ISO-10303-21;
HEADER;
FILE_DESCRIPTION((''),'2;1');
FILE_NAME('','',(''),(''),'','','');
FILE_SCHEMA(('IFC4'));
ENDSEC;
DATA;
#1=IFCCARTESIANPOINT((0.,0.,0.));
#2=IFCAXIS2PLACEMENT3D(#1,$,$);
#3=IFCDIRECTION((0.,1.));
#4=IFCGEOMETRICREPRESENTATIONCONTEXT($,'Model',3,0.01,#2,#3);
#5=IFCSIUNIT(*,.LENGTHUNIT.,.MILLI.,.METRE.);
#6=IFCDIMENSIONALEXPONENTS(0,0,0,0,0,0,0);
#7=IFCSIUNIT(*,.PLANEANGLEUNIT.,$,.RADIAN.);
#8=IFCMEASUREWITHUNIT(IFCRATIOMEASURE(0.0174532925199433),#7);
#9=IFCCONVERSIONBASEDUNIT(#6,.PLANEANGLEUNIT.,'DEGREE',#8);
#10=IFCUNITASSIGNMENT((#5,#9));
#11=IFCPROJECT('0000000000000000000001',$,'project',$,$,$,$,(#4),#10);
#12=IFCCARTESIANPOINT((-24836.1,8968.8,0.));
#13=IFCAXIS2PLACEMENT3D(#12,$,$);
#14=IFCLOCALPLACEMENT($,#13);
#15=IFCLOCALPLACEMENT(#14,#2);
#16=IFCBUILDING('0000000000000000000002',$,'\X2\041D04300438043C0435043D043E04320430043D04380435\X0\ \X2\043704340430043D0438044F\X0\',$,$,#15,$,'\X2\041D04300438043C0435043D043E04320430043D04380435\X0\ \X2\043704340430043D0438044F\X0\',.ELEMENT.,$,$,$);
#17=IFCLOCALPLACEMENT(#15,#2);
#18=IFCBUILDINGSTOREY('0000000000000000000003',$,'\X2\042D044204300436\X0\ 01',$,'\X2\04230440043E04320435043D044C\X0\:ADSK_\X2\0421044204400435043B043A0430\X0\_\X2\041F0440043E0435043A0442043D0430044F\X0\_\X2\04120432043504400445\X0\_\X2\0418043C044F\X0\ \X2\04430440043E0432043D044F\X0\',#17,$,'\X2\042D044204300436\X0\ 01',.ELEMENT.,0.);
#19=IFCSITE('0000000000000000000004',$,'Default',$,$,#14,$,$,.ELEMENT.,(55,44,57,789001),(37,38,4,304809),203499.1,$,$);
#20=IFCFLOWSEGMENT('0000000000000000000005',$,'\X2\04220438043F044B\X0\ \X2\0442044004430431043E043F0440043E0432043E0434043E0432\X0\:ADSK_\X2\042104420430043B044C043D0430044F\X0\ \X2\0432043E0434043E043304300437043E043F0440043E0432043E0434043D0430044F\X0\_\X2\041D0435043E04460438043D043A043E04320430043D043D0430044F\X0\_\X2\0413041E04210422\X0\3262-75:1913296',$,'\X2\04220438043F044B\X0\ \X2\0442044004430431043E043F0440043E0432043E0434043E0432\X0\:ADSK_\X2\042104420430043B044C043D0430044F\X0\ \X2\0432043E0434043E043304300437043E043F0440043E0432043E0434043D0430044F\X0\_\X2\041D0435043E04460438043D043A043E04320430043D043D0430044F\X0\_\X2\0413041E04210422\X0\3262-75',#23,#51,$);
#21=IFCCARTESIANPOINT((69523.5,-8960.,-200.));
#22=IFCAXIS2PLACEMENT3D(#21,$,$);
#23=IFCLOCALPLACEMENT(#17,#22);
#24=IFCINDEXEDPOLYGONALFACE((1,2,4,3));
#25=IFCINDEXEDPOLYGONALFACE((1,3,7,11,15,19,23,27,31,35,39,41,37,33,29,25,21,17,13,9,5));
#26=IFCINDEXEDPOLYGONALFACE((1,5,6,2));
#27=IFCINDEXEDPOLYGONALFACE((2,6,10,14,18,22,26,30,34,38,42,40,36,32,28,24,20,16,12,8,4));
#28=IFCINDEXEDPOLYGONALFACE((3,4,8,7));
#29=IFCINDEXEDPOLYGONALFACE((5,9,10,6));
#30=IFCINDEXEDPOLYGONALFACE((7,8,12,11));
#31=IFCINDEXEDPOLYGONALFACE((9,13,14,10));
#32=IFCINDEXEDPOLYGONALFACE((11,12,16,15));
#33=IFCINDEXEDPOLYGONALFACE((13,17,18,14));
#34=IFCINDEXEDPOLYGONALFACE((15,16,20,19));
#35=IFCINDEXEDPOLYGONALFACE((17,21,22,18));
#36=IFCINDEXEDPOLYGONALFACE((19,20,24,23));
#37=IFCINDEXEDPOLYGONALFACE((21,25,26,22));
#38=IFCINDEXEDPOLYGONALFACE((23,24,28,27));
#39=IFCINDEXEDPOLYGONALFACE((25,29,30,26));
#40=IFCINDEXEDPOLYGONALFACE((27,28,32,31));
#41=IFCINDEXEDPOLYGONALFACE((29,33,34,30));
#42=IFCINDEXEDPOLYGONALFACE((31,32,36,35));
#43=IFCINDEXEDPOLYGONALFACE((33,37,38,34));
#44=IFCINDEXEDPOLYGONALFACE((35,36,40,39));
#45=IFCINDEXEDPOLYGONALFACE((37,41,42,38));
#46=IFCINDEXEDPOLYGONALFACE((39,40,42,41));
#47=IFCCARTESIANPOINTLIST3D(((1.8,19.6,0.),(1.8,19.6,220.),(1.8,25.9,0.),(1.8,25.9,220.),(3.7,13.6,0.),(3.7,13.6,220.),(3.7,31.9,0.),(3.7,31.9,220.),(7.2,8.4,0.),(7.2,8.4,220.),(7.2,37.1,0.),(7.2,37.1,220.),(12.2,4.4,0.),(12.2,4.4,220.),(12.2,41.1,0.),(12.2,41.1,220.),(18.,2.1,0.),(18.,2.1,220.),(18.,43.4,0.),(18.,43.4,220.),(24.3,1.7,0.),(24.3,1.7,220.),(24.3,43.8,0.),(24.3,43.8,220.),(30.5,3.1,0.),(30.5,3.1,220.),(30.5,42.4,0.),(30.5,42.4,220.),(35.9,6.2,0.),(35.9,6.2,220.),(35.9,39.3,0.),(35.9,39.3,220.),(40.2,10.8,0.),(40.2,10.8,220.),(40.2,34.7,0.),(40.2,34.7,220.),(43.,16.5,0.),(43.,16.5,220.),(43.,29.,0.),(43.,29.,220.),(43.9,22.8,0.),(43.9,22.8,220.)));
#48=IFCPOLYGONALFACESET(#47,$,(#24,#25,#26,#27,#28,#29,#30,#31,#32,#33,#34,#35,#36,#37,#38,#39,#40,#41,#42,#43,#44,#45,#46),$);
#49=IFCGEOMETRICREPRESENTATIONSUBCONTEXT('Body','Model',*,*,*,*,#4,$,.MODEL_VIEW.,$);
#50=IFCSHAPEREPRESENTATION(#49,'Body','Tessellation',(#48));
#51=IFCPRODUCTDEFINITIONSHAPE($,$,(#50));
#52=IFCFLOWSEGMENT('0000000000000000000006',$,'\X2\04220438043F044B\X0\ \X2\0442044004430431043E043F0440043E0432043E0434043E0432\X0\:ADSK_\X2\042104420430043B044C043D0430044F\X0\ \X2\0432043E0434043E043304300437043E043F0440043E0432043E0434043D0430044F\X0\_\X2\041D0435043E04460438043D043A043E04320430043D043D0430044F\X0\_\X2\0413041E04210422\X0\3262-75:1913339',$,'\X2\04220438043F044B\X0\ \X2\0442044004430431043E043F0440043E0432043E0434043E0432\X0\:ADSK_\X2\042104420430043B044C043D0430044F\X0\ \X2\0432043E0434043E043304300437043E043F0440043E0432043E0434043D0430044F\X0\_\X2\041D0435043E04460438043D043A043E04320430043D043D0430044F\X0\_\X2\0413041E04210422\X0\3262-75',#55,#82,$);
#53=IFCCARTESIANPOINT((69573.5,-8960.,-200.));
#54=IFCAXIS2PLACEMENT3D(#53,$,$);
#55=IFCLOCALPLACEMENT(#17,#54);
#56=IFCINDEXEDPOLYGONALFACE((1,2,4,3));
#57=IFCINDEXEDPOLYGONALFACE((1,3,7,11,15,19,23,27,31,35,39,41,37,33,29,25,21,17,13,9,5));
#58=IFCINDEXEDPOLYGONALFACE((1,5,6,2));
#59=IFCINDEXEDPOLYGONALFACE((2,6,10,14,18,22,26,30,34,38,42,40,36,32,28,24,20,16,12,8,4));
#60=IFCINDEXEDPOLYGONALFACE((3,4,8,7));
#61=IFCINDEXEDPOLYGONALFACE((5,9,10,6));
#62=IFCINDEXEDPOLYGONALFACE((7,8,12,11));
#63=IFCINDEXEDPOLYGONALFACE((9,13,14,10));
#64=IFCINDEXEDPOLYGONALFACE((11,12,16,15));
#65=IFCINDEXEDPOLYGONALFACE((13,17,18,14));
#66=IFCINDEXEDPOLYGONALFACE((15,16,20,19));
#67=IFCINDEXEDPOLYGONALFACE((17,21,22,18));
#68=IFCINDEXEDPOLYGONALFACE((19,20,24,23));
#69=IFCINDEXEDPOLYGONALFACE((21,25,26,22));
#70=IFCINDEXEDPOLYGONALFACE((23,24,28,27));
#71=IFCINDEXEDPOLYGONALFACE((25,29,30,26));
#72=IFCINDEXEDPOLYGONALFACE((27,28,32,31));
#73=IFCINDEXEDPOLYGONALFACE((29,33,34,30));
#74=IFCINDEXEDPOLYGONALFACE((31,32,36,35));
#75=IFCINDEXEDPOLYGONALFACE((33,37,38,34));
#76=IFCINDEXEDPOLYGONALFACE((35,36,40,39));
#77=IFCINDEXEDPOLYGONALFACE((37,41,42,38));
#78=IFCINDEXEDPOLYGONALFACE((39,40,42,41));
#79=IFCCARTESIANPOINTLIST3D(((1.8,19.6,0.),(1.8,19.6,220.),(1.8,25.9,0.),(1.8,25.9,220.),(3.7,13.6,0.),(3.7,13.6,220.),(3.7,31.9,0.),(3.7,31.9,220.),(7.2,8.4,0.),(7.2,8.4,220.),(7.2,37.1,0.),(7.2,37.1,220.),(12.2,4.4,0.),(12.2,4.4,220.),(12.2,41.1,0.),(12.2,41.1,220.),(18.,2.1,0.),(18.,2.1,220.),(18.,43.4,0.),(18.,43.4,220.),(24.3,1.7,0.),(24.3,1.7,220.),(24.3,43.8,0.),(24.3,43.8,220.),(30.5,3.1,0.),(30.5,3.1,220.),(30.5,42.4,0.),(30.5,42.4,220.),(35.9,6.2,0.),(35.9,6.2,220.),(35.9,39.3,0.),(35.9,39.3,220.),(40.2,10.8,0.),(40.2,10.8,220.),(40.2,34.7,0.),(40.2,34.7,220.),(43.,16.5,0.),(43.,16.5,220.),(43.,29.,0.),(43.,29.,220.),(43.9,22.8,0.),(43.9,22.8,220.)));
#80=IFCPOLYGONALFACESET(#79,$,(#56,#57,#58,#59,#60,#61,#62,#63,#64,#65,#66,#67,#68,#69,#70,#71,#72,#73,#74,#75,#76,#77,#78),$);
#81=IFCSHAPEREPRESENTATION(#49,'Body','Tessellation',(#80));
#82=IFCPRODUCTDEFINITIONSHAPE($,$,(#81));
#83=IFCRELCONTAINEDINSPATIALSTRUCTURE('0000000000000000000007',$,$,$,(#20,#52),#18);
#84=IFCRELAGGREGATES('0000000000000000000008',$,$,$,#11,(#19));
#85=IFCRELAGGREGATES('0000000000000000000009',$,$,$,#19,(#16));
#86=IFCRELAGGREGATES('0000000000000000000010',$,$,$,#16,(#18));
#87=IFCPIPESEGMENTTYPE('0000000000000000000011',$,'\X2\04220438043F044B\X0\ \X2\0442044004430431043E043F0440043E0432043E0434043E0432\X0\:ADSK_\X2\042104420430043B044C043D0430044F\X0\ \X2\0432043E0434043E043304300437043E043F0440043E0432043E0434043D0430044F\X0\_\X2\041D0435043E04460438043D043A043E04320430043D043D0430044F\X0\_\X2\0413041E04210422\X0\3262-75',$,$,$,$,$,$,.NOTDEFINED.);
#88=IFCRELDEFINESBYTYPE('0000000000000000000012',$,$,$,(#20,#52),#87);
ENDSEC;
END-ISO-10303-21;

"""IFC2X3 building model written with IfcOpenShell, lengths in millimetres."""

from ifc_helpers import new_model, entity, si_unit, converted_unit, direction, frame, origin, origin_2d_with_axis, place, context, subcontext, project, spatial, circle, extrude, type_object, element, save


model = new_model("IFC2X3")

# Units and contexts
model_context = context("Model", 3, precision=0.01, world=origin(), true_north=direction((0.0, 1.0)))
body_context = subcontext(model_context, "Body", "Model", "MODEL_VIEW")
ifc_project = project(units=[si_unit("LENGTHUNIT", "METRE", prefix="MILLI"), converted_unit("PLANEANGLEUNIT", "DEGREE", entity("IfcRatioMeasure", 0.0174532925199433), si_unit("PLANEANGLEUNIT", "RADIAN"), dimensions=[0, 0, 0, 0, 0, 0, 0])], contexts=[model_context])

# Site, building, storey
site_placement = place(None, frame((-24836.1, 8968.8, 0.0)))
site = spatial("IfcSite", under=ifc_project, at=site_placement, Name="Default", CompositionType="ELEMENT", RefLatitude=(55, 44, 57, 789001), RefLongitude=(37, 38, 4, 304809), RefElevation=203499.1)
building_placement = place(site_placement, origin())
building = spatial("IfcBuilding", under=site, at=building_placement, Name="Наименование здания", LongName="Наименование здания", CompositionType="ELEMENT")
storey_placement = place(building_placement, origin())
storey = spatial("IfcBuildingStorey", under=building, at=storey_placement, Name="Этаж 01", ObjectType="Уровень:ADSK_Стрелка_Проектная_Вверх_Имя уровня", LongName="Этаж 01", CompositionType="ELEMENT", Elevation=0.0)

# Flow segments
pipe_segment_type_1 = type_object("IfcPipeSegmentType", Name="Типы трубопроводов:ADSK_Стальная водогазопроводная_Неоцинкованная_ГОСТ3262-75", PredefinedType="NOTDEFINED")
for number, where, name in (
    (1, (69523.5, -8960.0, -200.0), "Типы трубопроводов:ADSK_Стальная водогазопроводная_Неоцинкованная_ГОСТ3262-75:1913296"),
    (2, (69573.5, -8960.0, -200.0), "Типы трубопроводов:ADSK_Стальная водогазопроводная_Неоцинкованная_ГОСТ3262-75:1913339"),
):
    element("IfcFlowSegment", number, at=place(storey_placement, frame(where)), inside=storey, type_object=pipe_segment_type_1, Name=name, ObjectType="Типы трубопроводов:ADSK_Стальная водогазопроводная_Неоцинкованная_ГОСТ3262-75", context=body_context, shape_type="SweptSolid", body=[
        extrude(circle(Radius=21.1, at=origin_2d_with_axis()), frame((22.8, 22.8, 0.0)), (0.0, 0.0, 1.0), 220.0),
    ])

save(model, "model.ifc")
